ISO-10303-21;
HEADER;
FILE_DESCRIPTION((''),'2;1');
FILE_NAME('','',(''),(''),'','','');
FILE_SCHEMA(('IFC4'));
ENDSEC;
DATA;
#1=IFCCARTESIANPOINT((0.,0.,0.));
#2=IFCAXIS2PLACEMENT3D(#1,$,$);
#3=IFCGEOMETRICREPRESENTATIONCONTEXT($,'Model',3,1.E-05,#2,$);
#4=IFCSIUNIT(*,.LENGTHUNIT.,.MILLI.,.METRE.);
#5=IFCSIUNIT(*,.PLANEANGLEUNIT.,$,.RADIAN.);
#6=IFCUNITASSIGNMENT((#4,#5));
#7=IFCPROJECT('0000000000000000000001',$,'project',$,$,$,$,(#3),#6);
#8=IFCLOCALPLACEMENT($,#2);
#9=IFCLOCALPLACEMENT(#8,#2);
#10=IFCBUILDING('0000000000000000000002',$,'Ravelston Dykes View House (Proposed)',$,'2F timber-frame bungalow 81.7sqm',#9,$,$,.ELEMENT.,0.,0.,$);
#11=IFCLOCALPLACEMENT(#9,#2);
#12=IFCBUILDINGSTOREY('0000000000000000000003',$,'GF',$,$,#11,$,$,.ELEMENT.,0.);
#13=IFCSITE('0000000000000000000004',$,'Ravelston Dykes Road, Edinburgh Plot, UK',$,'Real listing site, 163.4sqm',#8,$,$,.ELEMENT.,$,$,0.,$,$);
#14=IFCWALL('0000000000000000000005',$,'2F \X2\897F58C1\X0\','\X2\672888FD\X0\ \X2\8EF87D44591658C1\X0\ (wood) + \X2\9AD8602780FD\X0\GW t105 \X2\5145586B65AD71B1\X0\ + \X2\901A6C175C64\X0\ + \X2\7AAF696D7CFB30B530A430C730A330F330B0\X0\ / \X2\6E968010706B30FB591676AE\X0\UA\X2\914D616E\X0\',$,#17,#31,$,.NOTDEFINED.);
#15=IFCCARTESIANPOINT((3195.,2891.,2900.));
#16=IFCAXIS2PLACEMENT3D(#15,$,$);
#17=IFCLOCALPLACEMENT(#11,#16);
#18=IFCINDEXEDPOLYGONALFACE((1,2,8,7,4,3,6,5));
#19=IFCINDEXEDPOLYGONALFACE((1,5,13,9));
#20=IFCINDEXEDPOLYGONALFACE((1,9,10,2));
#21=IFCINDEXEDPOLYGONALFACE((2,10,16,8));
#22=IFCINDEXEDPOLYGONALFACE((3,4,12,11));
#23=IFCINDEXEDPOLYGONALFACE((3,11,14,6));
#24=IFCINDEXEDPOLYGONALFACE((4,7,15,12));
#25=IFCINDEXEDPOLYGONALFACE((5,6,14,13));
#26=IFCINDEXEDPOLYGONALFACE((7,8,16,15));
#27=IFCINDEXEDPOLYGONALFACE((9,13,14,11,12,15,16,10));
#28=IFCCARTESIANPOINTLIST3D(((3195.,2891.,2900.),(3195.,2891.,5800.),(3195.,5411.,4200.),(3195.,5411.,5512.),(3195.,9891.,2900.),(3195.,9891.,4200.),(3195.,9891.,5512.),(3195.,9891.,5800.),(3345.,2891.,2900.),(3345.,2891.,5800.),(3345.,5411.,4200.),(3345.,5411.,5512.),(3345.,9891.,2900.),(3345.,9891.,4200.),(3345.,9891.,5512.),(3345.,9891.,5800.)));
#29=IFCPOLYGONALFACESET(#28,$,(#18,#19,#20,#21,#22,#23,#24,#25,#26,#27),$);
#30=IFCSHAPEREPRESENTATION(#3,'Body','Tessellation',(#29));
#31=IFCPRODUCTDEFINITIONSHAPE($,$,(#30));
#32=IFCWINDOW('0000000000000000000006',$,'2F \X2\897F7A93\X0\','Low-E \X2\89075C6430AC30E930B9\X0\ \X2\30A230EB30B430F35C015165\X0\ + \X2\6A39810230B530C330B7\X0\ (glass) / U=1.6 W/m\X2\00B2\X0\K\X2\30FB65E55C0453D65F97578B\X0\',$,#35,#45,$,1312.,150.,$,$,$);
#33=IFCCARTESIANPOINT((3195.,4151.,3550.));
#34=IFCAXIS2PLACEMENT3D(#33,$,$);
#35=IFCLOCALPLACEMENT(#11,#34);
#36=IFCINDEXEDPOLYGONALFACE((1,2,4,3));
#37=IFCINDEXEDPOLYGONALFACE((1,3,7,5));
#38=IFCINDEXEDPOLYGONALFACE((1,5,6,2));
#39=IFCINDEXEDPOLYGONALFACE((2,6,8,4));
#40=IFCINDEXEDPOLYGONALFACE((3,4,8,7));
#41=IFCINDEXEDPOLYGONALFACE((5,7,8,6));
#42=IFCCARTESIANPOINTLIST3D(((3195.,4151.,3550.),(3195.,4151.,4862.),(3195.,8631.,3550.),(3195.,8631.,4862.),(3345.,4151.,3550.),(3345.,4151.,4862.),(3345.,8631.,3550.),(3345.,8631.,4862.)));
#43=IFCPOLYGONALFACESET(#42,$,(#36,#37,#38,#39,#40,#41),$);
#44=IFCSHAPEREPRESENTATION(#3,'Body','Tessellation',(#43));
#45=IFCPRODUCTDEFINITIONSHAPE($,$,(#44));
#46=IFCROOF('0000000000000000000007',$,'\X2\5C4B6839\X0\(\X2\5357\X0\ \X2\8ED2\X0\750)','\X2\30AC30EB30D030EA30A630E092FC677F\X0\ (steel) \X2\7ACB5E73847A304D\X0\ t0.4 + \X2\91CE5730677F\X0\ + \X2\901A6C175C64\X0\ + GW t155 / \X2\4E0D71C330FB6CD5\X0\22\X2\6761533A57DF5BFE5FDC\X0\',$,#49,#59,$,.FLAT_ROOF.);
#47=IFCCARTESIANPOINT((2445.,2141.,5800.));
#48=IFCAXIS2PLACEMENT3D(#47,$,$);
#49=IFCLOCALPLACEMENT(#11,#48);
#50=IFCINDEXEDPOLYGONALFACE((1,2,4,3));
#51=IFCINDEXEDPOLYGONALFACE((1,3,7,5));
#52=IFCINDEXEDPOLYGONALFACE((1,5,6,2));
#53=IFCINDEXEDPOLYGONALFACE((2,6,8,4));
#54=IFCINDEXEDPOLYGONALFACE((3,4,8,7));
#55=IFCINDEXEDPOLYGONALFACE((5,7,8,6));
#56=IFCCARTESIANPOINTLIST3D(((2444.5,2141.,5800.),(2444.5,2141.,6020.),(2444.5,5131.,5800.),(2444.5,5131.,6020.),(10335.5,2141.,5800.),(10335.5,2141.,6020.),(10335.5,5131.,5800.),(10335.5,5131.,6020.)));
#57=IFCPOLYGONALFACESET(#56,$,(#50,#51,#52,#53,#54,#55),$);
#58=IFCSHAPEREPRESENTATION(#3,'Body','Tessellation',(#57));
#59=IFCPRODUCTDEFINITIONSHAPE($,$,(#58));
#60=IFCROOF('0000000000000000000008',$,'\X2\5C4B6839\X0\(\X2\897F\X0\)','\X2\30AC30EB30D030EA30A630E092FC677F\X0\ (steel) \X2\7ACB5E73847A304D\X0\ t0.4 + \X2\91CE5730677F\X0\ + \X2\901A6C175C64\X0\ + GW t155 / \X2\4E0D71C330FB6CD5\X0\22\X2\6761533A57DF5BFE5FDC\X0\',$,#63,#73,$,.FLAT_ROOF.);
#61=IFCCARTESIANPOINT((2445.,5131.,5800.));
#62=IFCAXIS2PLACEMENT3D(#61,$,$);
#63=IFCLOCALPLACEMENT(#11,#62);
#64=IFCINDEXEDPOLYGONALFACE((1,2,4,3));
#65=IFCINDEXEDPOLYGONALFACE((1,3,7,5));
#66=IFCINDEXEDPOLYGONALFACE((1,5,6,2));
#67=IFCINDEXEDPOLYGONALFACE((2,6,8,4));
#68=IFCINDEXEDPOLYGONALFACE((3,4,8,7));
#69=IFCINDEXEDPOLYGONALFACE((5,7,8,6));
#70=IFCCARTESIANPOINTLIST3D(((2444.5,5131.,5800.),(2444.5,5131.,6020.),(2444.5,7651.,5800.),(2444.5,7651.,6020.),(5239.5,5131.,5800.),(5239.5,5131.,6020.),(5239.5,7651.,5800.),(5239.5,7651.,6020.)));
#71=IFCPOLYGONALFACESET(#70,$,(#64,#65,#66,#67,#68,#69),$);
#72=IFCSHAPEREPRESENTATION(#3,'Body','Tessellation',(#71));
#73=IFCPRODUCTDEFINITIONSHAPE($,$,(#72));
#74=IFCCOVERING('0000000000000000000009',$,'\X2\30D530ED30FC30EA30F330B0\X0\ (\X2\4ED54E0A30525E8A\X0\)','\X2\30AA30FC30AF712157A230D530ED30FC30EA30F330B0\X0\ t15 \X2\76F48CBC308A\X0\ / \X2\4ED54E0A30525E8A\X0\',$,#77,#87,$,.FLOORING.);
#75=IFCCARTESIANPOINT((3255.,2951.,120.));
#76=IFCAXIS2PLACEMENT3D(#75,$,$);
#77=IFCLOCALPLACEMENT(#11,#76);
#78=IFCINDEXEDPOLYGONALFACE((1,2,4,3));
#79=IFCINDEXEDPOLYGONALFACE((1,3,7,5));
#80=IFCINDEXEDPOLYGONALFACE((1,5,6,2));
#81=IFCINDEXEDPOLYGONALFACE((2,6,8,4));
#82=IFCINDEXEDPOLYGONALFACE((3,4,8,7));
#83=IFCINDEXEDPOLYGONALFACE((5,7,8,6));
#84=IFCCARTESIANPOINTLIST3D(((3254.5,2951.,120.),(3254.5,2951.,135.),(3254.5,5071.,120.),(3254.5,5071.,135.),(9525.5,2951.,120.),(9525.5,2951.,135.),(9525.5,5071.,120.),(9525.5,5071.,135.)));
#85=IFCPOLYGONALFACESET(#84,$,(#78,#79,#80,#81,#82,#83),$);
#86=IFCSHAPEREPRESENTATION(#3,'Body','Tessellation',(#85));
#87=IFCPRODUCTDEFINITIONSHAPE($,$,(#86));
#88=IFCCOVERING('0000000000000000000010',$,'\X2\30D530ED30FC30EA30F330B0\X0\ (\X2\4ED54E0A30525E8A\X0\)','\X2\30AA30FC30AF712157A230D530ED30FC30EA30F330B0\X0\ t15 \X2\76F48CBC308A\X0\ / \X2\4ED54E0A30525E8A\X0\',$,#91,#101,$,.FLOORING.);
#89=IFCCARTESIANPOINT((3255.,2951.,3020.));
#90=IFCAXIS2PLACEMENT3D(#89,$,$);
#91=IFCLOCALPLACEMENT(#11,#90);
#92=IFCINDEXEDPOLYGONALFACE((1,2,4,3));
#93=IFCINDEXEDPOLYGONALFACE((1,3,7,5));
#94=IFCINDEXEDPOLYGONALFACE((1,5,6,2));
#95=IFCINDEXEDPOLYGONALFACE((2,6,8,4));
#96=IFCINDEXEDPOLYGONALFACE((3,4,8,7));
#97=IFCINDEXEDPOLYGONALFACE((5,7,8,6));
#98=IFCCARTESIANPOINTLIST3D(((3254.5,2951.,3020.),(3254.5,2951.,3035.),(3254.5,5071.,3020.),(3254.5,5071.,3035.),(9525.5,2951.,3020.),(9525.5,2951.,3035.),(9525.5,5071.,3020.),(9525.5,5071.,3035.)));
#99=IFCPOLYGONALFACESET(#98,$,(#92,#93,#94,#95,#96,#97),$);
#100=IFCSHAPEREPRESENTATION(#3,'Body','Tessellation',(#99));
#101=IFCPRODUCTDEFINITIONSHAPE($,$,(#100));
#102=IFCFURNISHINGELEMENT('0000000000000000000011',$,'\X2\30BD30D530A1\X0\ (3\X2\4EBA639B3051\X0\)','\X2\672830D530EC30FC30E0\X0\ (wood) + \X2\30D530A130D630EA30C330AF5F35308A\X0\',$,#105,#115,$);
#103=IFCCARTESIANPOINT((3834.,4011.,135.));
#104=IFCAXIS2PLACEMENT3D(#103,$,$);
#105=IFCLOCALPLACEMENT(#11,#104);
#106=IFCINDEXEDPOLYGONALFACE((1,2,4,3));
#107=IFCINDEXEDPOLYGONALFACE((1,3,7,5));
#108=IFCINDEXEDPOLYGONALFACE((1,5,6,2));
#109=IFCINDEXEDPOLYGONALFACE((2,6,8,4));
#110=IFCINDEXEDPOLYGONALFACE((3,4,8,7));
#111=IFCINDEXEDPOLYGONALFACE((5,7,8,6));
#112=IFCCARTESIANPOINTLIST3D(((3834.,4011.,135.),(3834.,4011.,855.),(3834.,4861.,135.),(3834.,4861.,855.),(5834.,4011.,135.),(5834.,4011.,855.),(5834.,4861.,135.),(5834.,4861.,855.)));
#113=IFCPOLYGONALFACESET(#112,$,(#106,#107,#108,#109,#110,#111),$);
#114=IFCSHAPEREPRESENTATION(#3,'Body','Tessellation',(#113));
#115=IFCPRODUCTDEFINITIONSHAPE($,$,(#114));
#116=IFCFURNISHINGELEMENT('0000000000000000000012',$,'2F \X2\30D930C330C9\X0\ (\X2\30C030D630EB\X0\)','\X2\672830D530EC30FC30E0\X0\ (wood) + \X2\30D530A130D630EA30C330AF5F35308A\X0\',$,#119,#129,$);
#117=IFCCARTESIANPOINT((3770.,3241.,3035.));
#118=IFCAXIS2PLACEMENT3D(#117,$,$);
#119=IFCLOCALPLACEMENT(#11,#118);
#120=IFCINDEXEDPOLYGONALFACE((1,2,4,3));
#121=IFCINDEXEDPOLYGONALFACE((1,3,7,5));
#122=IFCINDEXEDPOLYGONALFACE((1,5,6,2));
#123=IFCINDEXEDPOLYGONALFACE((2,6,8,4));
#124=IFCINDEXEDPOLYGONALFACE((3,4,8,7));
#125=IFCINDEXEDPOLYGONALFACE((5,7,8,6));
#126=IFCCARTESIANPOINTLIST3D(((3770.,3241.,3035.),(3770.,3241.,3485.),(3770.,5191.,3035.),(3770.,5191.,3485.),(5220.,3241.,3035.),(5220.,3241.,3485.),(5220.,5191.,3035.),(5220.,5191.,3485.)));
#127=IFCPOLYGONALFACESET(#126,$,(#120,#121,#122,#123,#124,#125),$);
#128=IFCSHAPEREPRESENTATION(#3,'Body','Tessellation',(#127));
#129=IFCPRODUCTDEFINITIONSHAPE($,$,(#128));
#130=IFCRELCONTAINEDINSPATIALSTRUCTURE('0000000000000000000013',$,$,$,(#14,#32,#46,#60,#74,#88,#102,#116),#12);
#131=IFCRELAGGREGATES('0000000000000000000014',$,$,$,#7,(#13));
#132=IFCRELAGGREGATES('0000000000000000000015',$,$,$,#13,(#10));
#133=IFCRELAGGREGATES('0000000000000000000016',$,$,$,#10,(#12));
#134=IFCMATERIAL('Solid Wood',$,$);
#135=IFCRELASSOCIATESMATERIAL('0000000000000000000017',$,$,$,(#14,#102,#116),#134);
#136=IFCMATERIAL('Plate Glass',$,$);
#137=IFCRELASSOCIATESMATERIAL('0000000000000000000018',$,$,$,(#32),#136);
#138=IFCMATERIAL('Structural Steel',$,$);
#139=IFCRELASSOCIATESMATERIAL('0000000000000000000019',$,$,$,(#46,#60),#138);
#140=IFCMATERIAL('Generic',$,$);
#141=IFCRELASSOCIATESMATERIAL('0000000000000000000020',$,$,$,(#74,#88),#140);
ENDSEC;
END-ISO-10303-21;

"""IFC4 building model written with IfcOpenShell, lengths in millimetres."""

from ifc_helpers import new_model, si_unit, frame, frame_2d, origin, place, context, project, spatial, rectangle, extrude, material, element, fill, save


model = new_model("IFC4")

# Units and contexts
model_context = context("Model", 3, precision=1e-05, world=origin())
ifc_project = project(units=[si_unit("LENGTHUNIT", "METRE", prefix="MILLI"), si_unit("PLANEANGLEUNIT", "RADIAN")], contexts=[model_context])

# Site, building, storey
site_placement = place(None, origin())
site = spatial("IfcSite", under=ifc_project, at=site_placement, Name="Ravelston Dykes Road, Edinburgh Plot, UK", ObjectType="Real listing site, 163.4sqm", CompositionType="ELEMENT", RefElevation=0.0)
building_placement = place(site_placement, origin())
building = spatial("IfcBuilding", under=site, at=building_placement, Name="Ravelston Dykes View House (Proposed)", ObjectType="2F timber-frame bungalow 81.7sqm", CompositionType="ELEMENT", ElevationOfRefHeight=0.0, ElevationOfTerrain=0.0)
storey_placement = place(building_placement, origin())
storey = spatial("IfcBuildingStorey", under=building, at=storey_placement, Name="GF", CompositionType="ELEMENT", Elevation=0.0)

# Shared definitions
ifc_material_1 = material(Name="Solid Wood")

# Shared definitions
ifc_material_2 = material(Name="Plate Glass")

# Wall, opening, window
wall_1_placement = place(storey_placement, frame((3195.0, 2891.0, 2900.0)))
wall_1 = element("IfcWall", 1, at=wall_1_placement, inside=storey, material=ifc_material_1, Name="2F 西壁", Description="木製 軸組外壁 (wood) + 高性能GW t105 充填断熱 + 通気層 + 窯業系サイディング / 準耐火・外皮UA配慮", PredefinedType="NOTDEFINED", context=model_context, shape_type="SweptSolid", body=[
    extrude(rectangle(XDim=150.0, YDim=7000.0, at=frame_2d((75.0, 3500.0))), frame((3195.0, 2891.0, 2900.0)), (0.0, 0.0, 1.0), 2900.0),
])
opening_1_placement = place(storey_placement, frame((3195.0, 4151.0, 3550.0)))
opening_1 = element("IfcOpeningElement", 2, at=opening_1_placement, cuts=wall_1, PredefinedType="NOTDEFINED", context=model_context, shape_type="SweptSolid", body=[
    extrude(rectangle(XDim=150.0, YDim=4480.0, at=frame_2d((75.0, 2240.0))), frame((3195.0, 4151.0, 3550.0)), (0.0, 0.0, 1.0), 1312.0),
])
window_1_placement = place(storey_placement, frame((3195.0, 4151.0, 3550.0)))
window_1 = element("IfcWindow", 3, at=window_1_placement, inside=storey, material=ifc_material_2, Name="2F 西窓", Description="Low-E 複層ガラス アルゴン封入 + 樹脂サッシ (glass) / U=1.6 W/m²K・日射取得型", OverallHeight=1312.0, OverallWidth=150.0, context=model_context, shape_type="SweptSolid", body=[
    extrude(rectangle(XDim=150.0, YDim=4480.0, at=frame_2d((75.0, 2240.0))), frame((3195.0, 4151.0, 3550.0)), (0.0, 0.0, 1.0), 1312.0),
])
fill(opening_1, window_1)

# Roofs
ifc_material_3 = material(Name="Structural Steel")
roof_1_placement = place(storey_placement, frame((2445.0, 2141.0, 5800.0)))
element("IfcRoof", 4, at=roof_1_placement, inside=storey, material=ifc_material_3, Name="屋根(南 軒750)", Description="ガルバリウム鋼板 (steel) 立平葺き t0.4 + 野地板 + 通気層 + GW t155 / 不燃・法22条区域対応", PredefinedType="FLAT_ROOF", context=model_context, shape_type="SweptSolid", body=[
    extrude(rectangle(XDim=7891.0, YDim=2990.0, at=frame_2d((3945.0, 1495.0))), frame((2445.0, 2141.0, 5800.0)), (0.0, 0.0, 1.0), 220.0),
])
roof_2_placement = place(storey_placement, frame((2445.0, 5131.0, 5800.0)))
element("IfcRoof", 5, at=roof_2_placement, inside=storey, material=ifc_material_3, Name="屋根(西)", Description="ガルバリウム鋼板 (steel) 立平葺き t0.4 + 野地板 + 通気層 + GW t155 / 不燃・法22条区域対応", PredefinedType="FLAT_ROOF", context=model_context, shape_type="SweptSolid", body=[
    extrude(rectangle(XDim=2795.0, YDim=2520.0, at=frame_2d((1397.0, 1260.0))), frame((2445.0, 5131.0, 5800.0)), (0.0, 0.0, 1.0), 220.0),
])

# Coverings
ifc_material_4 = material(Name="Generic")
covering_1_placement = place(storey_placement, frame((3255.0, 2951.0, 120.0)))
element("IfcCovering", 6, at=covering_1_placement, inside=storey, material=ifc_material_4, Name="フローリング (仕上げ床)", Description="オーク無垢フローリング t15 直貼り / 仕上げ床", PredefinedType="FLOORING", context=model_context, shape_type="SweptSolid", body=[
    extrude(rectangle(XDim=6271.0, YDim=2120.0, at=frame_2d((3135.0, 1060.0))), frame((3255.0, 2951.0, 120.0)), (0.0, 0.0, 1.0), 15.0),
])
covering_2_placement = place(storey_placement, frame((3255.0, 2951.0, 3020.0)))
element("IfcCovering", 7, at=covering_2_placement, inside=storey, material=ifc_material_4, Name="フローリング (仕上げ床)", Description="オーク無垢フローリング t15 直貼り / 仕上げ床", PredefinedType="FLOORING", context=model_context, shape_type="SweptSolid", body=[
    extrude(rectangle(XDim=6271.0, YDim=2120.0, at=frame_2d((3135.0, 1060.0))), frame((3255.0, 2951.0, 3020.0)), (0.0, 0.0, 1.0), 15.0),
])

# Furnishing elements
furnishing_1_placement = place(storey_placement, frame((3834.0, 4011.0, 135.0)))
element("IfcFurnishingElement", 8, at=furnishing_1_placement, inside=storey, material=ifc_material_1, Name="ソファ (3人掛け)", Description="木フレーム (wood) + ファブリック張り", context=model_context, shape_type="SweptSolid", body=[
    extrude(rectangle(XDim=2000.0, YDim=850.0, at=frame_2d((1000.0, 425.0))), frame((3834.0, 4011.0, 135.0)), (0.0, 0.0, 1.0), 720.0),
])
furnishing_2_placement = place(storey_placement, frame((3770.0, 3241.0, 3035.0)))
element("IfcFurnishingElement", 9, at=furnishing_2_placement, inside=storey, material=ifc_material_1, Name="2F ベッド (ダブル)", Description="木フレーム (wood) + ファブリック張り", context=model_context, shape_type="SweptSolid", body=[
    extrude(rectangle(XDim=1450.0, YDim=1950.0, at=frame_2d((725.0, 975.0))), frame((3770.0, 3241.0, 3035.0)), (0.0, 0.0, 1.0), 450.0),
])

save(model, "model.ifc")
